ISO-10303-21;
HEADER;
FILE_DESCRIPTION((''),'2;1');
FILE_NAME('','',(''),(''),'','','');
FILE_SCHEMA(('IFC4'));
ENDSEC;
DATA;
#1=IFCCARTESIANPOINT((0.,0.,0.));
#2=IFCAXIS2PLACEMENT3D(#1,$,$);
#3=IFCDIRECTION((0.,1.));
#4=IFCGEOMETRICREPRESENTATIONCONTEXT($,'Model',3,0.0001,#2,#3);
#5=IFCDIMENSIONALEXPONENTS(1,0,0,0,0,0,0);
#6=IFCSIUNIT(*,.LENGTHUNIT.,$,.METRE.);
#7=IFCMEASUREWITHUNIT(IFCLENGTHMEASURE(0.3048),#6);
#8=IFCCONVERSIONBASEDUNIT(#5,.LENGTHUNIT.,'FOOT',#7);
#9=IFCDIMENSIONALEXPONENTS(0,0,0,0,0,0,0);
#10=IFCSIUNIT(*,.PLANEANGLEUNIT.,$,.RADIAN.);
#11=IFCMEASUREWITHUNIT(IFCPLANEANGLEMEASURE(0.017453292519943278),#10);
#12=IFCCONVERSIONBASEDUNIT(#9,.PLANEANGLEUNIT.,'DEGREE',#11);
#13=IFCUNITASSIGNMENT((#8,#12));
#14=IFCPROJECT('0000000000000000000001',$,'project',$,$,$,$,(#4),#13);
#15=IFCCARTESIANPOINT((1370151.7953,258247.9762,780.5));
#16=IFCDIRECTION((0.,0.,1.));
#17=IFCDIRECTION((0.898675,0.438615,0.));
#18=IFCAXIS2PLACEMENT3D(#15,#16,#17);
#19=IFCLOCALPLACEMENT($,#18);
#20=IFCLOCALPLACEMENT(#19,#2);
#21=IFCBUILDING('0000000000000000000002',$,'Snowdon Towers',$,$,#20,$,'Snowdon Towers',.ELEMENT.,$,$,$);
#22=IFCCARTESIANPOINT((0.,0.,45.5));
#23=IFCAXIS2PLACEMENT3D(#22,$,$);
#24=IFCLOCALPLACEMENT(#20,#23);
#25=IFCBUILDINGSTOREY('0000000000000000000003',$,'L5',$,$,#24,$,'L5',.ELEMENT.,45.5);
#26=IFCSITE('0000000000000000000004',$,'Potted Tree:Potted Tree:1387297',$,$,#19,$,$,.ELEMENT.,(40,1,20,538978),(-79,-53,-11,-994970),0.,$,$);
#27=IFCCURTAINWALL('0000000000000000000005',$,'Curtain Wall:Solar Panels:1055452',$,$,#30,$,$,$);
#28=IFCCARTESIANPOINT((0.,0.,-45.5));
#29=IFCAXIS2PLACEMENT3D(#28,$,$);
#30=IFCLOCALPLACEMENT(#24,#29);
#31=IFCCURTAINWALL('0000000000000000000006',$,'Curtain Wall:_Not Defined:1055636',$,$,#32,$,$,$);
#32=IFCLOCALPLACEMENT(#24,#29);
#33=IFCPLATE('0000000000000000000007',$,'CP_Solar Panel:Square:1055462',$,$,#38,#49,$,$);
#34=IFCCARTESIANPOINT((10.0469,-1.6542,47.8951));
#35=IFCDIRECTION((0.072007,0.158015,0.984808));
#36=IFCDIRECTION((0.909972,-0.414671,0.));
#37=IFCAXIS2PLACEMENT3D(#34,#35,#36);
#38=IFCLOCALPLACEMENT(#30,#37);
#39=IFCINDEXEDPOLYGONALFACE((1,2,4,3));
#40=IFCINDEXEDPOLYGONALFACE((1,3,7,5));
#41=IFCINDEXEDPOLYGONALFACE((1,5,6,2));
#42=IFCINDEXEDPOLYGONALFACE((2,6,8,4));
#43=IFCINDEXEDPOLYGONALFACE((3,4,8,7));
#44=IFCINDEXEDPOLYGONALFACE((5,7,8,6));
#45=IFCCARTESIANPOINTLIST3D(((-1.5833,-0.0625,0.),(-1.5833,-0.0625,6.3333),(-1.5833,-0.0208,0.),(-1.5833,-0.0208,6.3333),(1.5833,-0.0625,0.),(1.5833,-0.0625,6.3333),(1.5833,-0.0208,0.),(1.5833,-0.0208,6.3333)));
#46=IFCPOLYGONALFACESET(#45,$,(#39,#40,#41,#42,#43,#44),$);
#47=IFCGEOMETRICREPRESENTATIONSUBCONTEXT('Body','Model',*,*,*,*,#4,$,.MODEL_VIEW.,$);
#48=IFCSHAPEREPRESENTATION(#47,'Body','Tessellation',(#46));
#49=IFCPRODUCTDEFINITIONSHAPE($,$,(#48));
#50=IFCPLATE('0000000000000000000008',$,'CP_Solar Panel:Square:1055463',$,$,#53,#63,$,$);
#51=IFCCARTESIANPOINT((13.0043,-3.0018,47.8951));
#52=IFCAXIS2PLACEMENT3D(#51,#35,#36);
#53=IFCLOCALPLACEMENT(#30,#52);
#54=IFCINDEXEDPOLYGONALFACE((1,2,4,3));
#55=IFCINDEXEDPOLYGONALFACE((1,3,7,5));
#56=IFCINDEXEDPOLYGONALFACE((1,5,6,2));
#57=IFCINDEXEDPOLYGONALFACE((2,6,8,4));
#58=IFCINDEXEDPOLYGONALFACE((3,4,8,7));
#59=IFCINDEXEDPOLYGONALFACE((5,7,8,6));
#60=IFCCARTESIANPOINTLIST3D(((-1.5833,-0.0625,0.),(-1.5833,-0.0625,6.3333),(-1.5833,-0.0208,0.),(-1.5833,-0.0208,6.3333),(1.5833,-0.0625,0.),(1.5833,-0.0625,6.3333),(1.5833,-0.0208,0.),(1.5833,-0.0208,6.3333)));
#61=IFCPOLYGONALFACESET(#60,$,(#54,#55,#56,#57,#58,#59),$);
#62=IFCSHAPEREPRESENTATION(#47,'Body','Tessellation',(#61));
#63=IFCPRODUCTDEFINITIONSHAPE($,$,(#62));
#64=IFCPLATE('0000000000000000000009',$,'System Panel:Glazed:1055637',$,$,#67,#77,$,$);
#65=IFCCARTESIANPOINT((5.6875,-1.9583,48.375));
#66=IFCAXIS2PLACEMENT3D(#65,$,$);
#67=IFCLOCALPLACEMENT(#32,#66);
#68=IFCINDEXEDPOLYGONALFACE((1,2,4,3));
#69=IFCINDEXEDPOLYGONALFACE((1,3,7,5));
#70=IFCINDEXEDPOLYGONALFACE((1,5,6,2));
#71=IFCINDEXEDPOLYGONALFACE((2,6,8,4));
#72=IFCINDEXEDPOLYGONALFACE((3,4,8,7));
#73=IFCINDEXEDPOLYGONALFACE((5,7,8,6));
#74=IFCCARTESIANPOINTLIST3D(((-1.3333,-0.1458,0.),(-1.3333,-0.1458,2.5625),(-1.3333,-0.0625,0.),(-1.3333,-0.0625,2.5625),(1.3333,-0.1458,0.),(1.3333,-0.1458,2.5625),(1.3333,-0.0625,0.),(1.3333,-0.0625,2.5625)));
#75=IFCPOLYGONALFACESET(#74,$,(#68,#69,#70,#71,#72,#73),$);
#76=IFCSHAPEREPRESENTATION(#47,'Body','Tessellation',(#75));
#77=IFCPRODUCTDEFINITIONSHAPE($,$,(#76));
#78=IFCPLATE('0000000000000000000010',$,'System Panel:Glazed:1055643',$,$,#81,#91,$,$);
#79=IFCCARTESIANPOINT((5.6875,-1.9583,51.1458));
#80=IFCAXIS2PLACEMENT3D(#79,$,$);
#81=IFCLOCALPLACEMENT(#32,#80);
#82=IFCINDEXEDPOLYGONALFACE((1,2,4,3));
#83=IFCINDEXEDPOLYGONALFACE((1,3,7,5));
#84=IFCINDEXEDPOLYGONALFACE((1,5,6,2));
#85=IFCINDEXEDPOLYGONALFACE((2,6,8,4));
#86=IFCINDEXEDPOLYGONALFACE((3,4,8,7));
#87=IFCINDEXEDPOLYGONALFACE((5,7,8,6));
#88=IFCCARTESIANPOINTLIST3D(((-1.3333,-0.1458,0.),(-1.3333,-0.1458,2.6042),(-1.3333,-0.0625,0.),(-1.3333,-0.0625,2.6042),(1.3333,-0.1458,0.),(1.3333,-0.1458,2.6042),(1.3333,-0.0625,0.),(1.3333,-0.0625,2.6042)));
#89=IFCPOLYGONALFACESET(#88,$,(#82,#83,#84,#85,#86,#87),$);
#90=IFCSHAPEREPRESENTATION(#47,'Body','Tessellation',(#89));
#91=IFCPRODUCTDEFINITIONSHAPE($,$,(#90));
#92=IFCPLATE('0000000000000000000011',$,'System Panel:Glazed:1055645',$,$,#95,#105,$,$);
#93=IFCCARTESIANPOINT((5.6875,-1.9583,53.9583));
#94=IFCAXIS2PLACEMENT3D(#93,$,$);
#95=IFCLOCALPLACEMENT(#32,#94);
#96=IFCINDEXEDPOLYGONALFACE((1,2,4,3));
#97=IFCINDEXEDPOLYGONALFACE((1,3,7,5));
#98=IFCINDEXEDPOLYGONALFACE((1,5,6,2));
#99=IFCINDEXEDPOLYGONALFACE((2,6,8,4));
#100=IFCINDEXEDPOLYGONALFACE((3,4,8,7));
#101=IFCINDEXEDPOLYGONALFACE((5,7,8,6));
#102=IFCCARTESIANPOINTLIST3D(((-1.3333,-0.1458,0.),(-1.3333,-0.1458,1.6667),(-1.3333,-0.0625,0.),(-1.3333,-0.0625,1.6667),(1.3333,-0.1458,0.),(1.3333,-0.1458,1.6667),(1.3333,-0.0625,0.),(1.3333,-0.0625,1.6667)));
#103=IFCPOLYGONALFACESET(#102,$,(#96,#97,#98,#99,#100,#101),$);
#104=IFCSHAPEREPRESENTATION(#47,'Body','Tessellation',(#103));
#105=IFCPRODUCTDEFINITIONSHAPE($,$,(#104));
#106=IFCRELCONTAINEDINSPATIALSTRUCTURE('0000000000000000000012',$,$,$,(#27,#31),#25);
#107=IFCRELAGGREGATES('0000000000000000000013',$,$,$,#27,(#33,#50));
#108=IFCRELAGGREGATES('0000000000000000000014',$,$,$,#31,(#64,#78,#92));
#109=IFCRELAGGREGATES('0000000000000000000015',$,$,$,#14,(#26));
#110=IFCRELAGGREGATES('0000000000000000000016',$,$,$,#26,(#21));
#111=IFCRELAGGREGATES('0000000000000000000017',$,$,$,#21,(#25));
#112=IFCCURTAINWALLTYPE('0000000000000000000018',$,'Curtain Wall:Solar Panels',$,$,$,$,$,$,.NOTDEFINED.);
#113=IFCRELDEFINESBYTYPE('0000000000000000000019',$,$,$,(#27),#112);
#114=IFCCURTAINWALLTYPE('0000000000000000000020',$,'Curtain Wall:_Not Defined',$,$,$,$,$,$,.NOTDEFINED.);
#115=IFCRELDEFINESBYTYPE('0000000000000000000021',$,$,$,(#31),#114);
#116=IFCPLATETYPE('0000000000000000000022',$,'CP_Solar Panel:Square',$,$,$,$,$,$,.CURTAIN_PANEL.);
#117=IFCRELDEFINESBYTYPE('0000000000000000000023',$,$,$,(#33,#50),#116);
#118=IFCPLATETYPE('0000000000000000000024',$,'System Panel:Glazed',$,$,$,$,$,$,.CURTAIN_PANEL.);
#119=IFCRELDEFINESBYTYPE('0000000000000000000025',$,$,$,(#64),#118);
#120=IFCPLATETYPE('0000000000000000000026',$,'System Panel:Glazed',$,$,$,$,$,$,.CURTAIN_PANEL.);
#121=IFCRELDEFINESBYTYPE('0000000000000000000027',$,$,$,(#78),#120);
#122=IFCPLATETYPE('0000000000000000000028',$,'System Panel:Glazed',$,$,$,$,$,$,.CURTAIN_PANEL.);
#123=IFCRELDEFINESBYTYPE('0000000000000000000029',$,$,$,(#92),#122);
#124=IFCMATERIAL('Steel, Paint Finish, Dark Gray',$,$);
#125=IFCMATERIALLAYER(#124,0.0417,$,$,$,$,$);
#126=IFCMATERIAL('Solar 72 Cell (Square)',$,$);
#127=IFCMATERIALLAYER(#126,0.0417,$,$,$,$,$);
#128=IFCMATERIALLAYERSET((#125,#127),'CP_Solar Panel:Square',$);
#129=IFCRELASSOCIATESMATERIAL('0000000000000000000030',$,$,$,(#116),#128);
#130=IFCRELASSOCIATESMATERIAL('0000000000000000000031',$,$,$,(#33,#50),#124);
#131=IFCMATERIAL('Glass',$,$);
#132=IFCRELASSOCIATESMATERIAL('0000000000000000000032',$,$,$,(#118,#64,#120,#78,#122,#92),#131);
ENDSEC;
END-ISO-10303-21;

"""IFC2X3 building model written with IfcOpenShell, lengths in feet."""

from ifc_helpers import new_model, entity, si_unit, converted_unit, direction, frame, frame_2d, origin, origin_2d_with_axis, place, context, subcontext, project, spatial, rectangle, extrude, source, transform, mapped, material, layer, layer_set, type_object, type_shapes, element, aggregate, save


model = new_model("IFC2X3")

# Units and contexts
model_context = context("Model", 3, precision=0.0001, world=origin(), true_north=direction((0.0, 1.0)))
body_context = subcontext(model_context, "Body", "Model", "MODEL_VIEW")
ifc_project = project(units=[converted_unit("LENGTHUNIT", "FOOT", entity("IfcLengthMeasure", 0.3048), si_unit("LENGTHUNIT", "METRE"), dimensions=[1, 0, 0, 0, 0, 0, 0]), converted_unit("PLANEANGLEUNIT", "DEGREE", entity("IfcPlaneAngleMeasure", 0.017453292519943278), si_unit("PLANEANGLEUNIT", "RADIAN"), dimensions=[0, 0, 0, 0, 0, 0, 0])], contexts=[model_context])

# Site, building, storey
site_placement = place(None, frame((1370151.7953, 258247.9762, 780.5), z_axis=(0.0, 0.0, 1.0), x_axis=(0.898675, 0.438615, 0.0)))
site = spatial("IfcSite", under=ifc_project, at=site_placement, Name="Potted Tree:Potted Tree:1387297", CompositionType="ELEMENT", RefLatitude=(40, 1, 20, 538978), RefLongitude=(-79, -53, -11, -994970), RefElevation=0.0)
building_placement = place(site_placement, origin())
building = spatial("IfcBuilding", under=site, at=building_placement, Name="Snowdon Towers", LongName="Snowdon Towers", CompositionType="ELEMENT")
storey_placement = place(building_placement, frame((0.0, 0.0, 45.5)))
storey = spatial("IfcBuildingStorey", under=building, at=storey_placement, Name="L5", LongName="L5", CompositionType="ELEMENT", Elevation=45.5)

# Curtain walls
curtain_wall_type_1 = type_object("IfcCurtainWallType", Name="Curtain Wall:Solar Panels", PredefinedType="NOTDEFINED")
curtain_wall_1_placement = place(storey_placement, frame((0.0, 0.0, -45.5)))
curtain_wall_1 = element("IfcCurtainWall", 1, at=curtain_wall_1_placement, inside=storey, type_object=curtain_wall_type_1, Name="Curtain Wall:Solar Panels:1055452")
ifc_material_1 = material(Name="Steel, Paint Finish, Dark Gray")
curtain_wall_type_2 = type_object("IfcCurtainWallType", Name="Curtain Wall:_Not Defined", PredefinedType="NOTDEFINED")
curtain_wall_2_placement = place(storey_placement, frame((0.0, 0.0, -45.5)))
curtain_wall_2 = element("IfcCurtainWall", 2, at=curtain_wall_2_placement, inside=storey, type_object=curtain_wall_type_2, Name="Curtain Wall:_Not Defined:1055636")

# Plates
ifc_layer_1 = layer(ifc_material_1, 0.0417)
ifc_material_2 = material(Name="Solar 72 Cell (Square)")
ifc_layer_2 = layer(ifc_material_2, 0.0417)
ifc_layer_set_1 = layer_set([ifc_layer_1, ifc_layer_2], Name="CP_Solar Panel:Square")
plate_type_1 = type_object("IfcPlateType", Name="CP_Solar Panel:Square", PredefinedType="CURTAIN_PANEL", material=ifc_layer_set_1)
shared_shape_1 = source(origin(), body_context, "Body", "SweptSolid", [
    extrude(rectangle(XDim=3.1667, YDim=0.0417, at=origin_2d_with_axis()), frame((0.0, -0.0417, 0.0)), (0.0, 0.0, 1.0), 6.3333),
])
type_shapes(plate_type_1, [shared_shape_1])
plate_1_placement = place(curtain_wall_1_placement, frame((10.0469, -1.6542, 47.8951), z_axis=(0.072007, 0.158015, 0.984808), x_axis=(0.909972, -0.414671, 0.0)))
plate_1 = element("IfcPlate", 3, at=plate_1_placement, type_object=plate_type_1, material=ifc_material_1, Name="CP_Solar Panel:Square:1055462", context=body_context, shape_type="MappedRepresentation", body=[
    mapped(shared_shape_1, transform((0.0, 0.0, 0.0), scale=1.0)),
])
plate_2_placement = place(curtain_wall_1_placement, frame((13.0043, -3.0018, 47.8951), z_axis=(0.072007, 0.158015, 0.984808), x_axis=(0.909972, -0.414671, 0.0)))
plate_2 = element("IfcPlate", 4, at=plate_2_placement, type_object=plate_type_1, material=ifc_material_1, Name="CP_Solar Panel:Square:1055463", context=body_context, shape_type="MappedRepresentation", body=[
    mapped(shared_shape_1, transform((0.0, 0.0, 0.0), scale=1.0)),
])
aggregate(curtain_wall_1, [plate_1, plate_2])
ifc_material_3 = material(Name="Glass")
plate_type_2 = type_object("IfcPlateType", Name="System Panel:Glazed", PredefinedType="CURTAIN_PANEL", material=ifc_material_3)
shared_shape_2 = source(origin(), body_context, "Body", "SweptSolid", [
    extrude(rectangle(XDim=0.0833, YDim=2.6667, at=frame_2d((0.0, 0.0), x_axis=(1.0, 0.0))), frame((0.0, -0.1042, 0.0), z_axis=(0.0, 0.0, 1.0), x_axis=(0.0, 1.0, 0.0)), (0.0, 0.0, 1.0), 2.5625),
])
type_shapes(plate_type_2, [shared_shape_2])
plate_3_placement = place(curtain_wall_2_placement, frame((5.6875, -1.9583, 48.375)))
plate_3 = element("IfcPlate", 5, at=plate_3_placement, type_object=plate_type_2, material=ifc_material_3, Name="System Panel:Glazed:1055637", context=body_context, shape_type="MappedRepresentation", body=[
    mapped(shared_shape_2, transform((0.0, 0.0, 0.0), scale=1.0)),
])
plate_type_3 = type_object("IfcPlateType", Name="System Panel:Glazed", PredefinedType="CURTAIN_PANEL", material=ifc_material_3)
shared_shape_3 = source(origin(), body_context, "Body", "SweptSolid", [
    extrude(rectangle(XDim=0.0833, YDim=2.6667, at=frame_2d((0.0, 0.0), x_axis=(1.0, 0.0))), frame((0.0, -0.1042, 0.0), z_axis=(0.0, 0.0, 1.0), x_axis=(0.0, 1.0, 0.0)), (0.0, 0.0, 1.0), 2.6042),
])
type_shapes(plate_type_3, [shared_shape_3])
plate_4_placement = place(curtain_wall_2_placement, frame((5.6875, -1.9583, 51.1458)))
plate_4 = element("IfcPlate", 6, at=plate_4_placement, type_object=plate_type_3, material=ifc_material_3, Name="System Panel:Glazed:1055643", context=body_context, shape_type="MappedRepresentation", body=[
    mapped(shared_shape_3, transform((0.0, 0.0, 0.0), scale=1.0)),
])
plate_type_4 = type_object("IfcPlateType", Name="System Panel:Glazed", PredefinedType="CURTAIN_PANEL", material=ifc_material_3)
shared_shape_4 = source(origin(), body_context, "Body", "SweptSolid", [
    extrude(rectangle(XDim=0.0833, YDim=2.6667, at=frame_2d((0.0, 0.0), x_axis=(1.0, 0.0))), frame((0.0, -0.1042, 0.0), z_axis=(0.0, 0.0, 1.0), x_axis=(0.0, 1.0, 0.0)), (0.0, 0.0, 1.0), 1.6667),
])
type_shapes(plate_type_4, [shared_shape_4])
plate_5_placement = place(curtain_wall_2_placement, frame((5.6875, -1.9583, 53.9583)))
plate_5 = element("IfcPlate", 7, at=plate_5_placement, type_object=plate_type_4, material=ifc_material_3, Name="System Panel:Glazed:1055645", context=body_context, shape_type="MappedRepresentation", body=[
    mapped(shared_shape_4, transform((0.0, 0.0, 0.0), scale=1.0)),
])
aggregate(curtain_wall_2, [plate_3, plate_4, plate_5])

save(model, "model.ifc")
